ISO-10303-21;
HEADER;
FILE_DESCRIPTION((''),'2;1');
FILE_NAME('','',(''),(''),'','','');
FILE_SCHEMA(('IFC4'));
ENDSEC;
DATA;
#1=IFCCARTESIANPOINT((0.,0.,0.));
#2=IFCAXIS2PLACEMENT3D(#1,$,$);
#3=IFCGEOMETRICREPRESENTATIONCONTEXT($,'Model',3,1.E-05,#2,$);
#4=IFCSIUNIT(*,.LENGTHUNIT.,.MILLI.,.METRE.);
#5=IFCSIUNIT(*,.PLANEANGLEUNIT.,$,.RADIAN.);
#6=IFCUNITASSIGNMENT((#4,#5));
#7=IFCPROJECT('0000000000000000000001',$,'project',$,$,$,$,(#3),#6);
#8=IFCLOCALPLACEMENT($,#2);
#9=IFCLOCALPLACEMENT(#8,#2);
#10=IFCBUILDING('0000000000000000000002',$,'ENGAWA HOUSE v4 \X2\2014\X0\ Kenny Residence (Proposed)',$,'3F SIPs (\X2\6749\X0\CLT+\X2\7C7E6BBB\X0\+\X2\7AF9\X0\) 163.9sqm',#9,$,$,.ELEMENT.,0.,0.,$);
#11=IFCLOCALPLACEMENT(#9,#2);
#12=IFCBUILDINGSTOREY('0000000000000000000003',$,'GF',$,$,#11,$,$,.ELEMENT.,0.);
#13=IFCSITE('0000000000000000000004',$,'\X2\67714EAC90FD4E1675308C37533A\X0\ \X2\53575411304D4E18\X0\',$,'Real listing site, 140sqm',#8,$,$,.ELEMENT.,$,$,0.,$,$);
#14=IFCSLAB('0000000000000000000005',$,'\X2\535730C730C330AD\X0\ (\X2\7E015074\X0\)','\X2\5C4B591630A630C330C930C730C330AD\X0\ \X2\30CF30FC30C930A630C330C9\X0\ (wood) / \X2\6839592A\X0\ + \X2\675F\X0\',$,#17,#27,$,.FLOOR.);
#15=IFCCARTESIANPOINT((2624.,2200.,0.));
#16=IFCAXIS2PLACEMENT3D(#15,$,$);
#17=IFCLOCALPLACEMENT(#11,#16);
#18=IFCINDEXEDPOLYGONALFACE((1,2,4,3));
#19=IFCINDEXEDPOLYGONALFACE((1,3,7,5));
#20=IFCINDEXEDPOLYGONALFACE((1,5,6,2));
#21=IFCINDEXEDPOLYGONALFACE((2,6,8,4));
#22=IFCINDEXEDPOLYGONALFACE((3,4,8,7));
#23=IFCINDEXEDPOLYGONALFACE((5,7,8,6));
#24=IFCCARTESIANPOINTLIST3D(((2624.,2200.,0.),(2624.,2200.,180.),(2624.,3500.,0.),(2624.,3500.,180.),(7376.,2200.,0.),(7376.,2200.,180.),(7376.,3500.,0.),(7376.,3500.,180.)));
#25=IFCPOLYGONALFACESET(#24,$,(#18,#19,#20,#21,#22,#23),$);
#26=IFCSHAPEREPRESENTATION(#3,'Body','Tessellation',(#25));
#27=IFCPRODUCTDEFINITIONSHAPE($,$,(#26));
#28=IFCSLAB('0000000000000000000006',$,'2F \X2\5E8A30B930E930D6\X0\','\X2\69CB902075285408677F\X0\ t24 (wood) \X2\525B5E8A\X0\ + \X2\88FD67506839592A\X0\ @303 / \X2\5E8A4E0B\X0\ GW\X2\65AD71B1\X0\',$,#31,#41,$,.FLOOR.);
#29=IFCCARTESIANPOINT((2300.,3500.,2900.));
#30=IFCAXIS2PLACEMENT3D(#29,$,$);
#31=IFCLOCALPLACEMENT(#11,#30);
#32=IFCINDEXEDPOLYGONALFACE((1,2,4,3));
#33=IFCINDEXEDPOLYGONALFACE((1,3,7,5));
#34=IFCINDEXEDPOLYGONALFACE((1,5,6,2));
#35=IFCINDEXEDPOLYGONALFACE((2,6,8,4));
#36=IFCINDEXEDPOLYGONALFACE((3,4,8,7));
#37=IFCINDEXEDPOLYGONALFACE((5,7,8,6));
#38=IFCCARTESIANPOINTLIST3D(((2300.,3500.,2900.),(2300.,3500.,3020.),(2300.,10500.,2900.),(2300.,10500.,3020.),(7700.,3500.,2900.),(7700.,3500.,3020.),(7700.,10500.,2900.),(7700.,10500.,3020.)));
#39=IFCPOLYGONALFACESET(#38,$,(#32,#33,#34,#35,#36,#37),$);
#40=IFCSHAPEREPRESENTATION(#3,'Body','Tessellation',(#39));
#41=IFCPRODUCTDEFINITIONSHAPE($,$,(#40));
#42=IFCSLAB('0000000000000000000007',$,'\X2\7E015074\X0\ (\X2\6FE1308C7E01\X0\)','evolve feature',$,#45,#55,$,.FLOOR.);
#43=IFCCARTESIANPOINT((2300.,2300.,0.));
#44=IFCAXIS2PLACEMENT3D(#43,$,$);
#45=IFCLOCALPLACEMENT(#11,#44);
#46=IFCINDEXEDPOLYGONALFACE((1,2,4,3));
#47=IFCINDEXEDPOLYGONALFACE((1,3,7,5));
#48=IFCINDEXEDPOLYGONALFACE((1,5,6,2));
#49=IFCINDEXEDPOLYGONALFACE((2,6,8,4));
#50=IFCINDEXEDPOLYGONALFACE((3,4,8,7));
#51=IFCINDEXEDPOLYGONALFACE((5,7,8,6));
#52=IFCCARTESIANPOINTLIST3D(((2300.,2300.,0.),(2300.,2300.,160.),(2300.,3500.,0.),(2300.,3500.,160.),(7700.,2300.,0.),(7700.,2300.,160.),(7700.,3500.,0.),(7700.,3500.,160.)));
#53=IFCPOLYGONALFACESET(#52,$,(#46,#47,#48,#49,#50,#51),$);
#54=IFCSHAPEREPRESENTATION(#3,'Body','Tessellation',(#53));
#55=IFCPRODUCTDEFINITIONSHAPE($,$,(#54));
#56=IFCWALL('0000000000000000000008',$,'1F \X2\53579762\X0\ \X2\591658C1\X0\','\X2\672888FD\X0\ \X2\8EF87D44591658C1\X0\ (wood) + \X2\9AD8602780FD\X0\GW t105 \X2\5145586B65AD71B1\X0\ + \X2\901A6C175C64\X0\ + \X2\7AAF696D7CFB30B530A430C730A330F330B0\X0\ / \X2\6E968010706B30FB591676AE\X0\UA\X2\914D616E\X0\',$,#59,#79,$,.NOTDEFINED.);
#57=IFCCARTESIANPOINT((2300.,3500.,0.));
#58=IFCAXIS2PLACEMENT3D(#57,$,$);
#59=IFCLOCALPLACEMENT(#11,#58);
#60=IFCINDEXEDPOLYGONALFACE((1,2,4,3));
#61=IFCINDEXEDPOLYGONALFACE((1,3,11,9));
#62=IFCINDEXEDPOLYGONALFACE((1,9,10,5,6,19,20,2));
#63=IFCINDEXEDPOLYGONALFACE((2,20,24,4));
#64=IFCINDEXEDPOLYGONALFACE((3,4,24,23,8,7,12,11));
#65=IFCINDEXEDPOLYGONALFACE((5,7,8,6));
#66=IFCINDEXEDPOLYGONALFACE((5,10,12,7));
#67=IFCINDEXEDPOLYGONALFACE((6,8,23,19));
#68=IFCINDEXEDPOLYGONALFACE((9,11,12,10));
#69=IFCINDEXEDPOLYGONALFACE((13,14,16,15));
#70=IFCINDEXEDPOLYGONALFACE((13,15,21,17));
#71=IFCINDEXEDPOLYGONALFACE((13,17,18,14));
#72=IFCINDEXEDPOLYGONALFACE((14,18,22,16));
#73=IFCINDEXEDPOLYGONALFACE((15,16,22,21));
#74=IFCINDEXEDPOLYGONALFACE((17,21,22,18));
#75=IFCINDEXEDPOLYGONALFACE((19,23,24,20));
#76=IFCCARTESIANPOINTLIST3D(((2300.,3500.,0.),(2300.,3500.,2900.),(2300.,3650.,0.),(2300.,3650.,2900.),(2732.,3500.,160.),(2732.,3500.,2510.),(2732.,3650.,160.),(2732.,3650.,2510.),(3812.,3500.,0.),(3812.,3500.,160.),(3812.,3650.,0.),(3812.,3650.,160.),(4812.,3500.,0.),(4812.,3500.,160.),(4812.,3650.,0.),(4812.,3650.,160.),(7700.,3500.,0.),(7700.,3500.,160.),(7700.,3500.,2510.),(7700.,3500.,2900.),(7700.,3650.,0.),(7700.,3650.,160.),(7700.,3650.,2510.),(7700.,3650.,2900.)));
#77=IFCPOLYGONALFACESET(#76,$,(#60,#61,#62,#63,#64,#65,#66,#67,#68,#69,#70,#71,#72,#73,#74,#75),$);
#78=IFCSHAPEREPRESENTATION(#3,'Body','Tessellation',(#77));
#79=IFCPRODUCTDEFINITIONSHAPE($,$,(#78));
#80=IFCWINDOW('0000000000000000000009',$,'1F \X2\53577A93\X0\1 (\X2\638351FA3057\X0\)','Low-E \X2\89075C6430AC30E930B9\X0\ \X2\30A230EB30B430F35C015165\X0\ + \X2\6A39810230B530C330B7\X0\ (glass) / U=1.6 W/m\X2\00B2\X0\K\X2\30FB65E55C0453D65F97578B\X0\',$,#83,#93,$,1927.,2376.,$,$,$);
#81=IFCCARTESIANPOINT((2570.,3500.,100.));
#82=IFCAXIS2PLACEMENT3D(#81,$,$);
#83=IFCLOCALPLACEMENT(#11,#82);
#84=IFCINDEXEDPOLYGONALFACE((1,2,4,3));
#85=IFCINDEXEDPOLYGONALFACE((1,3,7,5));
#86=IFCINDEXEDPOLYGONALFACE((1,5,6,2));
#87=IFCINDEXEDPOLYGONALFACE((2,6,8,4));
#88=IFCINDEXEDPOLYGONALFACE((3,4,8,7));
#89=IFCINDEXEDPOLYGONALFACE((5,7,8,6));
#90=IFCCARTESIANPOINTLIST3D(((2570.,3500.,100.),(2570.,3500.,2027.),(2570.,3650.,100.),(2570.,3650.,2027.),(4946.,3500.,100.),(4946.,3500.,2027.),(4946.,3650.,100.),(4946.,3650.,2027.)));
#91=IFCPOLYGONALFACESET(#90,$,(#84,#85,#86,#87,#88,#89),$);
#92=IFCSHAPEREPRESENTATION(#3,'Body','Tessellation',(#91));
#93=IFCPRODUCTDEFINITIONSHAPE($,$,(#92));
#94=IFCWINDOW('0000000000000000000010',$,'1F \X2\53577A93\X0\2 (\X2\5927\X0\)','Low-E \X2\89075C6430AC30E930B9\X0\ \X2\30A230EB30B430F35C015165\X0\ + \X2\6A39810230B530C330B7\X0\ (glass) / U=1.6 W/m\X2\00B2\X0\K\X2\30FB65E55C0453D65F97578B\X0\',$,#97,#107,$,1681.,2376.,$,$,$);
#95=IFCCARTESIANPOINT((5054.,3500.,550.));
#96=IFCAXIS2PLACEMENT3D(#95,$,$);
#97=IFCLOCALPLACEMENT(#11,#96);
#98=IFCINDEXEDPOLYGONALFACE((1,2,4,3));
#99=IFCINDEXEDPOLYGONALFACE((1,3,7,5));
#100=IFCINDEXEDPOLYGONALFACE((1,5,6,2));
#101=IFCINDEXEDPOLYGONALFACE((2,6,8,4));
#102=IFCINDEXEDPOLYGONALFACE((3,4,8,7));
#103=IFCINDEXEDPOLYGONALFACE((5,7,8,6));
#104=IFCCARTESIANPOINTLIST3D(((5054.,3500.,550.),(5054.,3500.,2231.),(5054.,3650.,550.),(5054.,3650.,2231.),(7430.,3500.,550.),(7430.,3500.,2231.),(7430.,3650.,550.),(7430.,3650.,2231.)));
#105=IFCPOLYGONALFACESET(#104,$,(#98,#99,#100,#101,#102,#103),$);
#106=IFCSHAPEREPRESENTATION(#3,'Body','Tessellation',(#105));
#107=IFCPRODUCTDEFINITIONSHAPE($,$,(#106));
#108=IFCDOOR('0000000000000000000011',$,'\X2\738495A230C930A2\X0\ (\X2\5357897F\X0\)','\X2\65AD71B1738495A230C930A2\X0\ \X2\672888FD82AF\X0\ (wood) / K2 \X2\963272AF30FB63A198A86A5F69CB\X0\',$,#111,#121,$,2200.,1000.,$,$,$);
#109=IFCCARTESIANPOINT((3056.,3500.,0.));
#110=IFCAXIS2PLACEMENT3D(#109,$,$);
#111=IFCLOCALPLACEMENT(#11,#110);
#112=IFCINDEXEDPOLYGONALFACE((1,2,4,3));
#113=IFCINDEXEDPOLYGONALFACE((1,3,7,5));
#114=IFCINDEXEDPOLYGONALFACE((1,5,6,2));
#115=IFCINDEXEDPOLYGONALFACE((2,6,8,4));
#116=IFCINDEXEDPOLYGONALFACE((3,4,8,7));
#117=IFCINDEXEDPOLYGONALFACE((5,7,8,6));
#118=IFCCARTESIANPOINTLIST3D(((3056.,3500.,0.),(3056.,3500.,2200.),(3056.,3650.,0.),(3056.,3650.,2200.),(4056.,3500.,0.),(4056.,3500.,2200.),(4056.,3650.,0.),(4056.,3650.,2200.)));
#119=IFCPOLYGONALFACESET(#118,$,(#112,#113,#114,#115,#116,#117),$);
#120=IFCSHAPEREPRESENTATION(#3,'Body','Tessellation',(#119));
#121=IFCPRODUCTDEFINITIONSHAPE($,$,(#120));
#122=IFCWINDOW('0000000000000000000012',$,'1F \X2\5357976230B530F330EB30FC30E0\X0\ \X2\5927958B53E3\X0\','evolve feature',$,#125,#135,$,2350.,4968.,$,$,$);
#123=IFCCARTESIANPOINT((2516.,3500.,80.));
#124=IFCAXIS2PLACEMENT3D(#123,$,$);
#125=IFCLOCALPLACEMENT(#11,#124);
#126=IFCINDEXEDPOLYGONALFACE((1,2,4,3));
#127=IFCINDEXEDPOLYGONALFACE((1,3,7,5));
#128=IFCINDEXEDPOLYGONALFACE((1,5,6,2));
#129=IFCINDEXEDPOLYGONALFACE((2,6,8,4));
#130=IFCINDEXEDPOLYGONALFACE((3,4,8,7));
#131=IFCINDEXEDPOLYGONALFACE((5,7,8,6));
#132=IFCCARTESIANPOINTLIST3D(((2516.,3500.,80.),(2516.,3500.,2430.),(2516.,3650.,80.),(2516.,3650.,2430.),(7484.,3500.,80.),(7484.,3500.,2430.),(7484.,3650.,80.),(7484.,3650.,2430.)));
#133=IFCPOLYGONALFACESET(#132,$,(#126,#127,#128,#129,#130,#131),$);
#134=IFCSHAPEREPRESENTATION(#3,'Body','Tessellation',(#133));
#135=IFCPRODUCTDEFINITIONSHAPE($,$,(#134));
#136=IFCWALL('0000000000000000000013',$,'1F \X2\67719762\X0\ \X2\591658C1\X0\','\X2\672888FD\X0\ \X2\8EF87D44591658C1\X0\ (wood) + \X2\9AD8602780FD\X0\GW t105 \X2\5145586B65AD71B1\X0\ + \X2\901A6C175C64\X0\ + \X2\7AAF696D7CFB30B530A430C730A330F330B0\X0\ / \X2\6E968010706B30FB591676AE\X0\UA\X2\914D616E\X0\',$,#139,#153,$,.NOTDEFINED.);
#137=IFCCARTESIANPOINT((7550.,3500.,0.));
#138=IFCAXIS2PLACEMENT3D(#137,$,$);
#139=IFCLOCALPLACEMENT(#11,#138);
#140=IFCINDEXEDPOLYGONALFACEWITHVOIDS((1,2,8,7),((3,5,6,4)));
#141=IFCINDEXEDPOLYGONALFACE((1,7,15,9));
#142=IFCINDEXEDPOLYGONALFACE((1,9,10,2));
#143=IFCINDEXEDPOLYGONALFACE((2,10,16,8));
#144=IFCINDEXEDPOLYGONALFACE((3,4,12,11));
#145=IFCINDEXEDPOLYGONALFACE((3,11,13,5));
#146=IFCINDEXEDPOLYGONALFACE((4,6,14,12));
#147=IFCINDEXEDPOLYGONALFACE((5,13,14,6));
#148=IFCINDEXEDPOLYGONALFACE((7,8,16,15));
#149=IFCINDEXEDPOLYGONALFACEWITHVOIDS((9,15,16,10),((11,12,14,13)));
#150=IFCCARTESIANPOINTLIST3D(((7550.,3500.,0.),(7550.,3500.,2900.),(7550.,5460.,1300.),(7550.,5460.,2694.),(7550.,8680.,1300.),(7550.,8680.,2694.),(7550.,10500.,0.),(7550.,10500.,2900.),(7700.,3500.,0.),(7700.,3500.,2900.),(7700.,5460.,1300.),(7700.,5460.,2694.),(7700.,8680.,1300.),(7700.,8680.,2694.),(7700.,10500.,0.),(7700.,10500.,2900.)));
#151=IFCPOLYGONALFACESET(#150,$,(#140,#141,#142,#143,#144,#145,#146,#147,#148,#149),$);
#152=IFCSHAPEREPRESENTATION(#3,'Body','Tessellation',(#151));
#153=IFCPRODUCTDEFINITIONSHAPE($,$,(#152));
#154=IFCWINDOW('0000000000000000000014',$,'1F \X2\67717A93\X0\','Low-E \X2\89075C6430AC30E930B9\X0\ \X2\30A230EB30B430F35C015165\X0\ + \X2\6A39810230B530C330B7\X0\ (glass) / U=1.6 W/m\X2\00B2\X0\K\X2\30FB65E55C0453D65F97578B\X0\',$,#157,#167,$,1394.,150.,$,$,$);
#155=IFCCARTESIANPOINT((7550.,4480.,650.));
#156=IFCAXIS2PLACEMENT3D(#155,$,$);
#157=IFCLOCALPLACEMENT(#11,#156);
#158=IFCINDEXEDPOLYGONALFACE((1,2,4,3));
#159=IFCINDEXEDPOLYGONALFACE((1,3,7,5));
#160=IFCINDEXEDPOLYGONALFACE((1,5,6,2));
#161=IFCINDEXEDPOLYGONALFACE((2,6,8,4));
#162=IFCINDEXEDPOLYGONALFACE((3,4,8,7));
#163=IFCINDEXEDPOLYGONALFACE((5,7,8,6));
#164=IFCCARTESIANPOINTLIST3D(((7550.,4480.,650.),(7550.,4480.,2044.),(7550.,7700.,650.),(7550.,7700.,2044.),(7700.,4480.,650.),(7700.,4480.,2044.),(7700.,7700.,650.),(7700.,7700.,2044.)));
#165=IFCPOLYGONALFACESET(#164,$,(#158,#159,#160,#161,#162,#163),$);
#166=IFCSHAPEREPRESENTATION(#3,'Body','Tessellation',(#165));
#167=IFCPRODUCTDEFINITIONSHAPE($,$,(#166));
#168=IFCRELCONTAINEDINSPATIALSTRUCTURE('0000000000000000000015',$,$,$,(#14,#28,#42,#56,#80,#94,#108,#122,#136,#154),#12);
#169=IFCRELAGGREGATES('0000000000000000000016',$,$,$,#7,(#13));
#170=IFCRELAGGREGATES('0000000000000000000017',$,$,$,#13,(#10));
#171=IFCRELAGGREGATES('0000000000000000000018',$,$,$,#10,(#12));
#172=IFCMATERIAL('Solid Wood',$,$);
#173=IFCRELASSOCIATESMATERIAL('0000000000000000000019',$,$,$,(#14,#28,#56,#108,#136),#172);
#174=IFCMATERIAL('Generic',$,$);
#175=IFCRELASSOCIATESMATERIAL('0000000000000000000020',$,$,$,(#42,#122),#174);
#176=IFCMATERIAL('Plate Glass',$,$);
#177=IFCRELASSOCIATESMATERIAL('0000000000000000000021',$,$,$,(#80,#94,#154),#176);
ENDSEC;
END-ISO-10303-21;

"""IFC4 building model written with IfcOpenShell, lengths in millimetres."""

from ifc_helpers import new_model, si_unit, frame, frame_2d, origin, place, context, project, spatial, rectangle, extrude, material, element, fill, save


model = new_model("IFC4")

# Units and contexts
model_context = context("Model", 3, precision=1e-05, world=origin())
ifc_project = project(units=[si_unit("LENGTHUNIT", "METRE", prefix="MILLI"), si_unit("PLANEANGLEUNIT", "RADIAN")], contexts=[model_context])

# Site, building, storey
site_placement = place(None, origin())
site = spatial("IfcSite", under=ifc_project, at=site_placement, Name="東京都世田谷区 南向き丘", ObjectType="Real listing site, 140sqm", CompositionType="ELEMENT", RefElevation=0.0)
building_placement = place(site_placement, origin())
building = spatial("IfcBuilding", under=site, at=building_placement, Name="ENGAWA HOUSE v4 — Kenny Residence (Proposed)", ObjectType="3F SIPs (杉CLT+籾殻+竹) 163.9sqm", CompositionType="ELEMENT", ElevationOfRefHeight=0.0, ElevationOfTerrain=0.0)
storey_placement = place(building_placement, origin())
storey = spatial("IfcBuildingStorey", under=building, at=storey_placement, Name="GF", CompositionType="ELEMENT", Elevation=0.0)

# Slabs
ifc_material_1 = material(Name="Solid Wood")
slab_1_placement = place(storey_placement, frame((2624.0, 2200.0, 0.0)))
element("IfcSlab", 1, at=slab_1_placement, inside=storey, material=ifc_material_1, Name="南デッキ (縁側)", Description="屋外ウッドデッキ ハードウッド (wood) / 根太 + 束", PredefinedType="FLOOR", context=model_context, shape_type="SweptSolid", body=[
    extrude(rectangle(XDim=4752.0, YDim=1300.0, at=frame_2d((2376.0, 650.0))), frame((2624.0, 2200.0, 0.0)), (0.0, 0.0, 1.0), 180.0),
])
slab_2_placement = place(storey_placement, frame((2300.0, 3500.0, 2900.0)))
element("IfcSlab", 2, at=slab_2_placement, inside=storey, material=ifc_material_1, Name="2F 床スラブ", Description="構造用合板 t24 (wood) 剛床 + 製材根太 @303 / 床下 GW断熱", PredefinedType="FLOOR", context=model_context, shape_type="SweptSolid", body=[
    extrude(rectangle(XDim=5400.0, YDim=7000.0, at=frame_2d((2700.0, 3500.0))), frame((2300.0, 3500.0, 2900.0)), (0.0, 0.0, 1.0), 120.0),
])
ifc_material_2 = material(Name="Generic")
slab_3_placement = place(storey_placement, frame((2300.0, 2300.0, 0.0)))
element("IfcSlab", 3, at=slab_3_placement, inside=storey, material=ifc_material_2, Name="縁側 (濡れ縁)", Description="evolve feature", PredefinedType="FLOOR", context=model_context, shape_type="SweptSolid", body=[
    extrude(rectangle(XDim=5400.0, YDim=1200.0, at=frame_2d((2700.0, 600.0))), frame((2300.0, 2300.0, 0.0)), (0.0, 0.0, 1.0), 160.0),
])

# Wall, openings, windows, door
wall_1_placement = place(storey_placement, frame((2300.0, 3500.0, 0.0)))
wall_1 = element("IfcWall", 4, at=wall_1_placement, inside=storey, material=ifc_material_1, Name="1F 南面 外壁", Description="木製 軸組外壁 (wood) + 高性能GW t105 充填断熱 + 通気層 + 窯業系サイディング / 準耐火・外皮UA配慮", PredefinedType="NOTDEFINED", context=model_context, shape_type="SweptSolid", body=[
    extrude(rectangle(XDim=5400.0, YDim=150.0, at=frame_2d((2700.0, 75.0))), frame((2300.0, 3500.0, 0.0)), (0.0, 0.0, 1.0), 2900.0),
])
opening_1_placement = place(storey_placement, frame((2570.0, 3500.0, 100.0)))
opening_1 = element("IfcOpeningElement", 5, at=opening_1_placement, cuts=wall_1, PredefinedType="NOTDEFINED", context=model_context, shape_type="SweptSolid", body=[
    extrude(rectangle(XDim=2376.0, YDim=150.0, at=frame_2d((1188.0, 75.0))), frame((2570.0, 3500.0, 100.0)), (0.0, 0.0, 1.0), 1927.0),
])
opening_2_placement = place(storey_placement, frame((5054.0, 3500.0, 550.0)))
opening_2 = element("IfcOpeningElement", 6, at=opening_2_placement, cuts=wall_1, PredefinedType="NOTDEFINED", context=model_context, shape_type="SweptSolid", body=[
    extrude(rectangle(XDim=2376.0, YDim=150.0, at=frame_2d((1188.0, 75.0))), frame((5054.0, 3500.0, 550.0)), (0.0, 0.0, 1.0), 1681.0),
])
opening_3_placement = place(storey_placement, frame((3056.0, 3500.0, 0.0)))
opening_3 = element("IfcOpeningElement", 7, at=opening_3_placement, cuts=wall_1, PredefinedType="NOTDEFINED", context=model_context, shape_type="SweptSolid", body=[
    extrude(rectangle(XDim=1000.0, YDim=150.0, at=frame_2d((500.0, 75.0))), frame((3056.0, 3500.0, 0.0)), (0.0, 0.0, 1.0), 2200.0),
])
opening_4_placement = place(storey_placement, frame((2516.0, 3500.0, 80.0)))
opening_4 = element("IfcOpeningElement", 8, at=opening_4_placement, cuts=wall_1, PredefinedType="NOTDEFINED", context=model_context, shape_type="SweptSolid", body=[
    extrude(rectangle(XDim=4968.0, YDim=150.0, at=frame_2d((2484.0, 75.0))), frame((2516.0, 3500.0, 80.0)), (0.0, 0.0, 1.0), 2350.0),
])
ifc_material_3 = material(Name="Plate Glass")
window_1_placement = place(storey_placement, frame((2570.0, 3500.0, 100.0)))
window_1 = element("IfcWindow", 9, at=window_1_placement, inside=storey, material=ifc_material_3, Name="1F 南窓1 (掃出し)", Description="Low-E 複層ガラス アルゴン封入 + 樹脂サッシ (glass) / U=1.6 W/m²K・日射取得型", OverallHeight=1927.0, OverallWidth=2376.0, context=model_context, shape_type="SweptSolid", body=[
    extrude(rectangle(XDim=2376.0, YDim=150.0, at=frame_2d((1188.0, 75.0))), frame((2570.0, 3500.0, 100.0)), (0.0, 0.0, 1.0), 1927.0),
])
fill(opening_1, window_1)
window_2_placement = place(storey_placement, frame((5054.0, 3500.0, 550.0)))
window_2 = element("IfcWindow", 10, at=window_2_placement, inside=storey, material=ifc_material_3, Name="1F 南窓2 (大)", Description="Low-E 複層ガラス アルゴン封入 + 樹脂サッシ (glass) / U=1.6 W/m²K・日射取得型", OverallHeight=1681.0, OverallWidth=2376.0, context=model_context, shape_type="SweptSolid", body=[
    extrude(rectangle(XDim=2376.0, YDim=150.0, at=frame_2d((1188.0, 75.0))), frame((5054.0, 3500.0, 550.0)), (0.0, 0.0, 1.0), 1681.0),
])
fill(opening_2, window_2)
door_placement = place(storey_placement, frame((3056.0, 3500.0, 0.0)))
door = element("IfcDoor", 11, at=door_placement, inside=storey, material=ifc_material_1, Name="玄関ドア (南西)", Description="断熱玄関ドア 木製芯 (wood) / K2 防犯・採風機構", OverallHeight=2200.0, OverallWidth=1000.0, context=model_context, shape_type="SweptSolid", body=[
    extrude(rectangle(XDim=1000.0, YDim=150.0, at=frame_2d((500.0, 75.0))), frame((3056.0, 3500.0, 0.0)), (0.0, 0.0, 1.0), 2200.0),
])
fill(opening_3, door)
window_3_placement = place(storey_placement, frame((2516.0, 3500.0, 80.0)))
window_3 = element("IfcWindow", 12, at=window_3_placement, inside=storey, material=ifc_material_2, Name="1F 南面サンルーム 大開口", Description="evolve feature", OverallHeight=2350.0, OverallWidth=4968.0, context=model_context, shape_type="SweptSolid", body=[
    extrude(rectangle(XDim=4968.0, YDim=150.0, at=frame_2d((2484.0, 75.0))), frame((2516.0, 3500.0, 80.0)), (0.0, 0.0, 1.0), 2350.0),
])
fill(opening_4, window_3)

# Wall, opening, window
wall_2_placement = place(storey_placement, frame((7550.0, 3500.0, 0.0)))
wall_2 = element("IfcWall", 13, at=wall_2_placement, inside=storey, material=ifc_material_1, Name="1F 東面 外壁", Description="木製 軸組外壁 (wood) + 高性能GW t105 充填断熱 + 通気層 + 窯業系サイディング / 準耐火・外皮UA配慮", PredefinedType="NOTDEFINED", context=model_context, shape_type="SweptSolid", body=[
    extrude(rectangle(XDim=150.0, YDim=7000.0, at=frame_2d((75.0, 3500.0))), frame((7550.0, 3500.0, 0.0)), (0.0, 0.0, 1.0), 2900.0),
])
opening_5_placement = place(storey_placement, frame((7550.0, 4480.0, 650.0)))
opening_5 = element("IfcOpeningElement", 14, at=opening_5_placement, cuts=wall_2, PredefinedType="NOTDEFINED", context=model_context, shape_type="SweptSolid", body=[
    extrude(rectangle(XDim=150.0, YDim=3220.0, at=frame_2d((75.0, 1610.0))), frame((7550.0, 4480.0, 650.0)), (0.0, 0.0, 1.0), 1394.0),
])
window_4_placement = place(storey_placement, frame((7550.0, 4480.0, 650.0)))
window_4 = element("IfcWindow", 15, at=window_4_placement, inside=storey, material=ifc_material_3, Name="1F 東窓", Description="Low-E 複層ガラス アルゴン封入 + 樹脂サッシ (glass) / U=1.6 W/m²K・日射取得型", OverallHeight=1394.0, OverallWidth=150.0, context=model_context, shape_type="SweptSolid", body=[
    extrude(rectangle(XDim=150.0, YDim=3220.0, at=frame_2d((75.0, 1610.0))), frame((7550.0, 4480.0, 650.0)), (0.0, 0.0, 1.0), 1394.0),
])
fill(opening_5, window_4)

save(model, "model.ifc")
